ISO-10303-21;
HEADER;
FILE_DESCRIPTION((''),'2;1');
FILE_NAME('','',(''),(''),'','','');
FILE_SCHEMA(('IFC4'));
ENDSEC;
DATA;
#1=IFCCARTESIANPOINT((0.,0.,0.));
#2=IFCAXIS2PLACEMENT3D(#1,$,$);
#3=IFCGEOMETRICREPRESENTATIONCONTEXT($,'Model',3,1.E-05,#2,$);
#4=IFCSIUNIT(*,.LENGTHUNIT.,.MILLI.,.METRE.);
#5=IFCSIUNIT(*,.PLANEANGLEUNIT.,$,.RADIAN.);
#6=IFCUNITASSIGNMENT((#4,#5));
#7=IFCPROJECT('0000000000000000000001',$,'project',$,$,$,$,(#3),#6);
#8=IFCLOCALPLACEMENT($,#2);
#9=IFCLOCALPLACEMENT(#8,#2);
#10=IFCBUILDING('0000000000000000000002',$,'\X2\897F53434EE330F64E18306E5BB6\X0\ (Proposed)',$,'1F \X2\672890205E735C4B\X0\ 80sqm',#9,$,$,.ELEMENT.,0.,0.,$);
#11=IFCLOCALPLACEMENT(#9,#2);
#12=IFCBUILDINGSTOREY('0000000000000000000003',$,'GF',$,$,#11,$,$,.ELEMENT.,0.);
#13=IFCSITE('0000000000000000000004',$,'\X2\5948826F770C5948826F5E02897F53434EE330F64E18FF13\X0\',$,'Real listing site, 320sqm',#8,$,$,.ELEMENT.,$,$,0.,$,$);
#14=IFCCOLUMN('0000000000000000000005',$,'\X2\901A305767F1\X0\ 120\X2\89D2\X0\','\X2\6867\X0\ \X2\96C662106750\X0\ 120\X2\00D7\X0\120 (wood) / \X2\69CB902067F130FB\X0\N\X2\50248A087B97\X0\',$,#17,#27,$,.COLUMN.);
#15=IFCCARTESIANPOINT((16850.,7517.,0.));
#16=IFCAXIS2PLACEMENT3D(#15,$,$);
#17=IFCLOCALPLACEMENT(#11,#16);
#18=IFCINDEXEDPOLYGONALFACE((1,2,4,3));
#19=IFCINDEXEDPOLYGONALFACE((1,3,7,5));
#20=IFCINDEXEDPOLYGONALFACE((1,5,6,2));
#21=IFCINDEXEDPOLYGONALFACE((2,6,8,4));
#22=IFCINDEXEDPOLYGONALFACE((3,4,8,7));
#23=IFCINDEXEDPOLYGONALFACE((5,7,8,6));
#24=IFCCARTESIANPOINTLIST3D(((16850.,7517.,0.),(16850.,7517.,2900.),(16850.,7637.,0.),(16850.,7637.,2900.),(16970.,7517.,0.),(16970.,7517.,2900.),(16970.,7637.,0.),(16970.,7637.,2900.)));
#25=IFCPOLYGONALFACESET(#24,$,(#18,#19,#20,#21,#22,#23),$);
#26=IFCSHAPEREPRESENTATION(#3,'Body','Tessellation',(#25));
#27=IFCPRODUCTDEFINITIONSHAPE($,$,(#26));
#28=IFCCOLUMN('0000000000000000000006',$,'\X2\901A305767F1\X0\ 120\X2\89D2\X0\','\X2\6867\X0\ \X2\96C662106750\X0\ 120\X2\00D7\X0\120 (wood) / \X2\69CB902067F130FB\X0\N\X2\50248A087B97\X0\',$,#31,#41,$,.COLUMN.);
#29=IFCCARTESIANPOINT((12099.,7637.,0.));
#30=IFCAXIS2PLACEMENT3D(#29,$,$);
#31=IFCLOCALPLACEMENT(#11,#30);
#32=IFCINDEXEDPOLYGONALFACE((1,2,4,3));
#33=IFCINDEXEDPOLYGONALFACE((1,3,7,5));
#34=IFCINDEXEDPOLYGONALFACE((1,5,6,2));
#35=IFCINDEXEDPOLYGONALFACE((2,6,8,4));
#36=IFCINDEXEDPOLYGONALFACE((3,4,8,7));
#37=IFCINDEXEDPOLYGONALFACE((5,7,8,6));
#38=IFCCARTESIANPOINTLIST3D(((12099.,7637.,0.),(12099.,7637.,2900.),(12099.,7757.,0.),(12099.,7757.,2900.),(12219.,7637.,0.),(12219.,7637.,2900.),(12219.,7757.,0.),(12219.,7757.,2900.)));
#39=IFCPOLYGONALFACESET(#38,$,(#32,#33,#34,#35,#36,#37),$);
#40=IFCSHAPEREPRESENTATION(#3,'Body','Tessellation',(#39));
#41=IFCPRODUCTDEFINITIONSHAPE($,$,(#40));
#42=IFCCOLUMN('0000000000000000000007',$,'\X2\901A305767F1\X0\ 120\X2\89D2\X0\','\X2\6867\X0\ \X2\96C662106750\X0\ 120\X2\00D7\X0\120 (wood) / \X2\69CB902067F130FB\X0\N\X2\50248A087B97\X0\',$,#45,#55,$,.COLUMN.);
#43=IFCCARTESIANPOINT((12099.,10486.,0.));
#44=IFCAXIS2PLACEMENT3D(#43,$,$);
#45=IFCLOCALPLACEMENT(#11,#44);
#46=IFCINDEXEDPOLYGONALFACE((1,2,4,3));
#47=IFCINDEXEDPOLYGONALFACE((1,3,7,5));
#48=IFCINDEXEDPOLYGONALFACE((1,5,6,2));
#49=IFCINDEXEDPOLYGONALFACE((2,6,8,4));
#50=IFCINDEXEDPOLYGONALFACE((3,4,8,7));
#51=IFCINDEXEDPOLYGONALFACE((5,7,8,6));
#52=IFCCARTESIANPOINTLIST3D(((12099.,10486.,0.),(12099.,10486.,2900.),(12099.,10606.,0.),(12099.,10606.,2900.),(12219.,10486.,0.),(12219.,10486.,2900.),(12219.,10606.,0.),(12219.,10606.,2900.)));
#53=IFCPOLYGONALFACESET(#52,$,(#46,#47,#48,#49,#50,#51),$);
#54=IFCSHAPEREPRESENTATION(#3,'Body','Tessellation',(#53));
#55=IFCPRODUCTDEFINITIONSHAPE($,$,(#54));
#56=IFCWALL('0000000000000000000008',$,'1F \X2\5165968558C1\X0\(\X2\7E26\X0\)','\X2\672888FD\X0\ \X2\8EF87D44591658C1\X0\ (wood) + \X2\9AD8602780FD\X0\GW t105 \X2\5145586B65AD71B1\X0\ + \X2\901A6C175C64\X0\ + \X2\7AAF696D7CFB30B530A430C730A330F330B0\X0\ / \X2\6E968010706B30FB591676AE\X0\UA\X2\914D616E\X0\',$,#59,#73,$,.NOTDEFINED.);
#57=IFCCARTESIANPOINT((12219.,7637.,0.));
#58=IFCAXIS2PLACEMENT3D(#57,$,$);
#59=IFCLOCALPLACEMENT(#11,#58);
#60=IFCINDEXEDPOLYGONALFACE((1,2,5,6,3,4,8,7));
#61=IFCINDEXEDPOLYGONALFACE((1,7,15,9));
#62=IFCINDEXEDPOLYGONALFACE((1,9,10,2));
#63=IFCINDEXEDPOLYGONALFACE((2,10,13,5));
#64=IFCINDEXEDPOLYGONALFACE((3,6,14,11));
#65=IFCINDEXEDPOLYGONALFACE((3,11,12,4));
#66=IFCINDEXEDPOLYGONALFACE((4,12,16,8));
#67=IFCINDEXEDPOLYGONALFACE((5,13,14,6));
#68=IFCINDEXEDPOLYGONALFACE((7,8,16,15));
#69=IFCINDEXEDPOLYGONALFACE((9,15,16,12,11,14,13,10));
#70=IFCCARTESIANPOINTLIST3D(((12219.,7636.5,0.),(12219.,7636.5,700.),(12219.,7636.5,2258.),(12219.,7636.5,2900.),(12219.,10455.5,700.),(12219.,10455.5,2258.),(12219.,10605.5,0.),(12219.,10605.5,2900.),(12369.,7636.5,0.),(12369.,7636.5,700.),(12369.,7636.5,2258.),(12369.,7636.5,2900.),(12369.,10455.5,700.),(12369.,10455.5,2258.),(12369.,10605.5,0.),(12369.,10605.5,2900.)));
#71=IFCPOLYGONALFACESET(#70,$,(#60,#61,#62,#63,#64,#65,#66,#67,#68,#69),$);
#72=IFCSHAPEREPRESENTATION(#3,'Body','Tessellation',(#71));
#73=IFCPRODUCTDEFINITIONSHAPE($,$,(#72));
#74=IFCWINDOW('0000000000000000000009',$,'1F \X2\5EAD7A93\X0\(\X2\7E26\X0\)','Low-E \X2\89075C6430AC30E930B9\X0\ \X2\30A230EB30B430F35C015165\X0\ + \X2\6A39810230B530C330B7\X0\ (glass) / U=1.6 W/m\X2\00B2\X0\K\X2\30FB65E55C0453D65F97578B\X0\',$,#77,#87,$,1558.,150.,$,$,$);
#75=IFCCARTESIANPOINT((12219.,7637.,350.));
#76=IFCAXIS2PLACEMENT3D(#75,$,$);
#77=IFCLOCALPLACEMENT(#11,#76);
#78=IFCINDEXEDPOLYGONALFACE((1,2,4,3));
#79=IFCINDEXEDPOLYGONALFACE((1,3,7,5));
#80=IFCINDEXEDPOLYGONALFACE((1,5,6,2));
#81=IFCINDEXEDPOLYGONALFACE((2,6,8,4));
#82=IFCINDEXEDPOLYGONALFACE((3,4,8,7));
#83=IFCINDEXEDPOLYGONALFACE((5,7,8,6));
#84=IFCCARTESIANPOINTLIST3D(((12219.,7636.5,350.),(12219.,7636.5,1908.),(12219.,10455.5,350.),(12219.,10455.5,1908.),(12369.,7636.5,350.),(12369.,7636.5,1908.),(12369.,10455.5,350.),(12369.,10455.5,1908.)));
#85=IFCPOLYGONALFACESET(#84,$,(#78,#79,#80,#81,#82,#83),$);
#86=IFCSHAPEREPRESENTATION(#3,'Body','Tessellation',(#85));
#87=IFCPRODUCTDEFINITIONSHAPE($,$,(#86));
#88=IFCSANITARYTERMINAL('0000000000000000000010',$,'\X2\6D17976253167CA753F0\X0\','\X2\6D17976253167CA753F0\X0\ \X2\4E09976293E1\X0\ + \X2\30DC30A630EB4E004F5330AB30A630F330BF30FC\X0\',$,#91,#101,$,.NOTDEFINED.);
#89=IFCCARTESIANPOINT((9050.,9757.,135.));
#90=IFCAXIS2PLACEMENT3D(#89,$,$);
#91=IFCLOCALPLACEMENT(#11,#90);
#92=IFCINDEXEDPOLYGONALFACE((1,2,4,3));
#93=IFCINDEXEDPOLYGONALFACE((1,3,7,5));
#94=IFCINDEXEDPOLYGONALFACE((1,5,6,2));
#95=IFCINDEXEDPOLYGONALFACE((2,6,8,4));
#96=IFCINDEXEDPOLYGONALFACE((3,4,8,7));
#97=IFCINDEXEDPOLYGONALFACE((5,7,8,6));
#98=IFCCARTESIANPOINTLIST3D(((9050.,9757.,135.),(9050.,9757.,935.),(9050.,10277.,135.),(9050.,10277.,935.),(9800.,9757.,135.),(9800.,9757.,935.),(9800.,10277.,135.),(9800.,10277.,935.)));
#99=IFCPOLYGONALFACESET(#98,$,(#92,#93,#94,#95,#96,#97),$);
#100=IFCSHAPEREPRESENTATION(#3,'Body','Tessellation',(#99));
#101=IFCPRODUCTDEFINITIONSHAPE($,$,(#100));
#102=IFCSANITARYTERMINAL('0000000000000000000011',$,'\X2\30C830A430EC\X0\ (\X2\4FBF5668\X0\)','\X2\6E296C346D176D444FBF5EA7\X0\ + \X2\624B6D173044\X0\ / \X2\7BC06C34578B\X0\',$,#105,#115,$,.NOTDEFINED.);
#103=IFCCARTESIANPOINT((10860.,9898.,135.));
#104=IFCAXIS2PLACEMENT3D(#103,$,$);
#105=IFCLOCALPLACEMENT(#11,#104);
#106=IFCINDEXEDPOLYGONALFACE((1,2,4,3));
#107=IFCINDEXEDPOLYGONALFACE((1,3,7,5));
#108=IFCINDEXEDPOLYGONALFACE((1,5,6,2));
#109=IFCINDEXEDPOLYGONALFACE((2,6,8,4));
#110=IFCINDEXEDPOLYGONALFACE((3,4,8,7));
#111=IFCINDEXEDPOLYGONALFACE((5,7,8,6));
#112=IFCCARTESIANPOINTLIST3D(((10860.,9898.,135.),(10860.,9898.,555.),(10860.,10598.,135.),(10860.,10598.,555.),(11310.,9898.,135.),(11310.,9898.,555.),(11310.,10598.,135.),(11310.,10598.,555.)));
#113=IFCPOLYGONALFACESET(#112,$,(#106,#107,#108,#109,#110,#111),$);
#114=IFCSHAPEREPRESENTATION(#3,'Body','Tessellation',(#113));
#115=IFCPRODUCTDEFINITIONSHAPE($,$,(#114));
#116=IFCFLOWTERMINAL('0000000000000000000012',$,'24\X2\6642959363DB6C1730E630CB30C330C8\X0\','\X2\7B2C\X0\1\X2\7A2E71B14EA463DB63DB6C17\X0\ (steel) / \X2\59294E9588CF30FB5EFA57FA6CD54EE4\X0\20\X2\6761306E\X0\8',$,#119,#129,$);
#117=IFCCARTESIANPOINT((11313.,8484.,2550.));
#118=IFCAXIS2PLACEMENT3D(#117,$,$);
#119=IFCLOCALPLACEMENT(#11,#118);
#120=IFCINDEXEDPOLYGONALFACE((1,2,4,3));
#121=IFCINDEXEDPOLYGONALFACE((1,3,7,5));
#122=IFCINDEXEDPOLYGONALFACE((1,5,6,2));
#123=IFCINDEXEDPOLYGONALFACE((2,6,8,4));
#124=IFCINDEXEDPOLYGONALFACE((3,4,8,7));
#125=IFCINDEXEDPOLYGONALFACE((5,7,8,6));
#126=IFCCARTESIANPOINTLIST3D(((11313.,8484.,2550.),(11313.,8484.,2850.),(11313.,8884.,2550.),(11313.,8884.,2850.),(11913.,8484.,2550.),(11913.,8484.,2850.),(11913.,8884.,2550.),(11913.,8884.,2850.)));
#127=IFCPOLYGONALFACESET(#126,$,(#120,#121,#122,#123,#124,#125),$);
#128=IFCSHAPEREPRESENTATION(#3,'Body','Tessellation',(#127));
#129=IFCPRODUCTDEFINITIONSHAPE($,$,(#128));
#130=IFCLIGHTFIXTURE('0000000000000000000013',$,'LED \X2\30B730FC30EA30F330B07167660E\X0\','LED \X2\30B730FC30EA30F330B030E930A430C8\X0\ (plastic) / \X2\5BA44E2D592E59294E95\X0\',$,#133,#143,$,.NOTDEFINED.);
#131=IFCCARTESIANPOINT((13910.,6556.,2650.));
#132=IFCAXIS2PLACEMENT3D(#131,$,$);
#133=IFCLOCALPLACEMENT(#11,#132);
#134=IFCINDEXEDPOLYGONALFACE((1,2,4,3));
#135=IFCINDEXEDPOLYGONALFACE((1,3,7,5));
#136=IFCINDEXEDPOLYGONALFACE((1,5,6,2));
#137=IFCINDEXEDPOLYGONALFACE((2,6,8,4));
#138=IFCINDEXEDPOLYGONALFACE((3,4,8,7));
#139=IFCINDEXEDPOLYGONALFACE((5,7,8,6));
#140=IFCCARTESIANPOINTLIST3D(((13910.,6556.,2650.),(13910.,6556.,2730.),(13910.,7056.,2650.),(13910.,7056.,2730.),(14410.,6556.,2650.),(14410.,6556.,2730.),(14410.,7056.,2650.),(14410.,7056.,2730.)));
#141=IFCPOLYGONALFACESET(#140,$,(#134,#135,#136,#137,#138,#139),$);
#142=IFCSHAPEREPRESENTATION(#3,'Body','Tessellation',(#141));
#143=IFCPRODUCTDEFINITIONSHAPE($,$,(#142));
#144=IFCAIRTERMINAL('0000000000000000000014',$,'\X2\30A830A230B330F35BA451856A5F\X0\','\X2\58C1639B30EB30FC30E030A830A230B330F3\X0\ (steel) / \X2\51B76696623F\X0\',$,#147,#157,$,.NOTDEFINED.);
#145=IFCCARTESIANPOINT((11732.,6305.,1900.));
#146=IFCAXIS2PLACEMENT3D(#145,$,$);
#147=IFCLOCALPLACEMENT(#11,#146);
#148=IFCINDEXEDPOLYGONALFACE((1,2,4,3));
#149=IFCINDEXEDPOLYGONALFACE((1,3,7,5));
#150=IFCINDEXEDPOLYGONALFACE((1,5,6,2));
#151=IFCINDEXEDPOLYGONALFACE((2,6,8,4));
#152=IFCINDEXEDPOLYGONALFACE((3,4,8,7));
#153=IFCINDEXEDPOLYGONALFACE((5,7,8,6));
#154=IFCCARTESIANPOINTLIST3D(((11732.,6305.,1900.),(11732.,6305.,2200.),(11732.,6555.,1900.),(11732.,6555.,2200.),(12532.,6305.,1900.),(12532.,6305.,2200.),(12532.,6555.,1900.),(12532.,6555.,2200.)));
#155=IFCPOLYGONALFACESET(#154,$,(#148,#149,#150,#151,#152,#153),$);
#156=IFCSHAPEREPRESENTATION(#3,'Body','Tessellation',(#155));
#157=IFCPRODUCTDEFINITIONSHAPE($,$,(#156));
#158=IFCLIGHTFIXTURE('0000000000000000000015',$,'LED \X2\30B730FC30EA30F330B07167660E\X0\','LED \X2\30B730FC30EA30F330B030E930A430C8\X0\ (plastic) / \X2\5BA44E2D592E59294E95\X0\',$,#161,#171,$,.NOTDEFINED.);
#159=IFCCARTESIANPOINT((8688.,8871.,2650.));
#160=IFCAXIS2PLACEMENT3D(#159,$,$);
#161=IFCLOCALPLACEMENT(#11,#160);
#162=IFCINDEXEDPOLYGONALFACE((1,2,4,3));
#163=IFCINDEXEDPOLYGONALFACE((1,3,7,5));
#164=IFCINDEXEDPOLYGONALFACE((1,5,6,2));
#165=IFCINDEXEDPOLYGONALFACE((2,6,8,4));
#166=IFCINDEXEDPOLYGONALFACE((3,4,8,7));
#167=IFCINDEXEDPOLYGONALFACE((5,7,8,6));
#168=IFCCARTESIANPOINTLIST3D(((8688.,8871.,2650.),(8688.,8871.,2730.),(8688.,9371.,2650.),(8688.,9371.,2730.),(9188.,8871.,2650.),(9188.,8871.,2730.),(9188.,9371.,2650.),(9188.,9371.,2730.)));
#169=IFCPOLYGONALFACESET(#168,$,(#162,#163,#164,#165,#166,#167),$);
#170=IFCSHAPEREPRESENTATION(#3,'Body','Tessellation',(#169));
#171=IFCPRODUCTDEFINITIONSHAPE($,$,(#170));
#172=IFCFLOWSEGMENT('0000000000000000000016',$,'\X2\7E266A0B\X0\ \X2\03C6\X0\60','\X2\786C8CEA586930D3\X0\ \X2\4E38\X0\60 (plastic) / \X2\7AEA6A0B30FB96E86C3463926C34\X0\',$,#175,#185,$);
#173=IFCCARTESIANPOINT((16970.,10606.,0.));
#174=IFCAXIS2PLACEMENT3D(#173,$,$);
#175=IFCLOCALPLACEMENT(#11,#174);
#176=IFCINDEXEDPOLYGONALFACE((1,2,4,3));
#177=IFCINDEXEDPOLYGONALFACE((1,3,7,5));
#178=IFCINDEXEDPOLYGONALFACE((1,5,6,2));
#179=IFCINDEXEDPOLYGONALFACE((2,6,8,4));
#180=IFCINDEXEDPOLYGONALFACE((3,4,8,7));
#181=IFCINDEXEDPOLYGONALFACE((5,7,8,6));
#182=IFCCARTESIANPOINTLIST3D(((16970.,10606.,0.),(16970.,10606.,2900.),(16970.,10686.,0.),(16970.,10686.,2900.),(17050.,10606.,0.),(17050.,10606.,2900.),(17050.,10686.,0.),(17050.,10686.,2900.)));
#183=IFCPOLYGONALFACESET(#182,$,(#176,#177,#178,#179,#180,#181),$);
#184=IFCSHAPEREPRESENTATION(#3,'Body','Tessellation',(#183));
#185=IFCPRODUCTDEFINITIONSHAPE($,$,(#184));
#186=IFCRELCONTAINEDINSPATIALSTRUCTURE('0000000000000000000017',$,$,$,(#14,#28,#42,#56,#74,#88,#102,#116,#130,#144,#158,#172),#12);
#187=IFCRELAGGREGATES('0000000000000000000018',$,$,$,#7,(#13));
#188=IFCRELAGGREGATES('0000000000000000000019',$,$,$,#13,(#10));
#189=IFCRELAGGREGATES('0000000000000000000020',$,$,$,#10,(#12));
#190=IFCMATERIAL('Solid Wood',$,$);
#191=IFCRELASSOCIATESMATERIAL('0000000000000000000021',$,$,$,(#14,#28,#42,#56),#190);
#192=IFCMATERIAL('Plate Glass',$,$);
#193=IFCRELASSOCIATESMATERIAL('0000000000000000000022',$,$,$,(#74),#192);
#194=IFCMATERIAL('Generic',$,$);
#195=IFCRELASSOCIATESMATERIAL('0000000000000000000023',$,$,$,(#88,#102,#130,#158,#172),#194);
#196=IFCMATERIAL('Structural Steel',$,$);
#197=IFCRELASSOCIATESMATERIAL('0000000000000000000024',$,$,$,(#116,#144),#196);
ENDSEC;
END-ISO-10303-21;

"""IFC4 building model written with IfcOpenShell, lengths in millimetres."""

from ifc_helpers import new_model, si_unit, frame, frame_2d, origin, place, context, project, spatial, rectangle, extrude, material, element, fill, save


model = new_model("IFC4")

# Units and contexts
model_context = context("Model", 3, precision=1e-05, world=origin())
ifc_project = project(units=[si_unit("LENGTHUNIT", "METRE", prefix="MILLI"), si_unit("PLANEANGLEUNIT", "RADIAN")], contexts=[model_context])

# Site, building, storey
site_placement = place(None, origin())
site = spatial("IfcSite", under=ifc_project, at=site_placement, Name="奈良県奈良市西千代ヶ丘３", ObjectType="Real listing site, 320sqm", CompositionType="ELEMENT", RefElevation=0.0)
building_placement = place(site_placement, origin())
building = spatial("IfcBuilding", under=site, at=building_placement, Name="西千代ヶ丘の家 (Proposed)", ObjectType="1F 木造平屋 80sqm", CompositionType="ELEMENT", ElevationOfRefHeight=0.0, ElevationOfTerrain=0.0)
storey_placement = place(building_placement, origin())
storey = spatial("IfcBuildingStorey", under=building, at=storey_placement, Name="GF", CompositionType="ELEMENT", Elevation=0.0)

# Columns
ifc_material_1 = material(Name="Solid Wood")
column_1_placement = place(storey_placement, frame((16850.0, 7517.0, 0.0)))
element("IfcColumn", 1, at=column_1_placement, inside=storey, material=ifc_material_1, Name="通し柱 120角", Description="桧 集成材 120×120 (wood) / 構造柱・N値計算", PredefinedType="COLUMN", context=model_context, shape_type="SweptSolid", body=[
    extrude(rectangle(XDim=120.0, YDim=120.0, at=frame_2d((60.0, 60.0))), frame((16850.0, 7517.0, 0.0)), (0.0, 0.0, 1.0), 2900.0),
])
column_2_placement = place(storey_placement, frame((12099.0, 7637.0, 0.0)))
element("IfcColumn", 2, at=column_2_placement, inside=storey, material=ifc_material_1, Name="通し柱 120角", Description="桧 集成材 120×120 (wood) / 構造柱・N値計算", PredefinedType="COLUMN", context=model_context, shape_type="SweptSolid", body=[
    extrude(rectangle(XDim=120.0, YDim=120.0, at=frame_2d((60.0, 60.0))), frame((12099.0, 7637.0, 0.0)), (0.0, 0.0, 1.0), 2900.0),
])
column_3_placement = place(storey_placement, frame((12099.0, 10486.0, 0.0)))
element("IfcColumn", 3, at=column_3_placement, inside=storey, material=ifc_material_1, Name="通し柱 120角", Description="桧 集成材 120×120 (wood) / 構造柱・N値計算", PredefinedType="COLUMN", context=model_context, shape_type="SweptSolid", body=[
    extrude(rectangle(XDim=120.0, YDim=120.0, at=frame_2d((60.0, 60.0))), frame((12099.0, 10486.0, 0.0)), (0.0, 0.0, 1.0), 2900.0),
])

# Wall, opening, window
wall_1_placement = place(storey_placement, frame((12219.0, 7637.0, 0.0)))
wall_1 = element("IfcWall", 4, at=wall_1_placement, inside=storey, material=ifc_material_1, Name="1F 入隅壁(縦)", Description="木製 軸組外壁 (wood) + 高性能GW t105 充填断熱 + 通気層 + 窯業系サイディング / 準耐火・外皮UA配慮", PredefinedType="NOTDEFINED", context=model_context, shape_type="SweptSolid", body=[
    extrude(rectangle(XDim=150.0, YDim=2969.0, at=frame_2d((75.0, 1484.0))), frame((12219.0, 7637.0, 0.0)), (0.0, 0.0, 1.0), 2900.0),
])
opening_placement = place(storey_placement, frame((12219.0, 7637.0, 350.0)))
opening = element("IfcOpeningElement", 5, at=opening_placement, cuts=wall_1, PredefinedType="NOTDEFINED", context=model_context, shape_type="SweptSolid", body=[
    extrude(rectangle(XDim=150.0, YDim=2819.0, at=frame_2d((75.0, 1409.0))), frame((12219.0, 7637.0, 350.0)), (0.0, 0.0, 1.0), 1558.0),
])
ifc_material_2 = material(Name="Plate Glass")
window_placement = place(storey_placement, frame((12219.0, 7637.0, 350.0)))
window = element("IfcWindow", 6, at=window_placement, inside=storey, material=ifc_material_2, Name="1F 庭窓(縦)", Description="Low-E 複層ガラス アルゴン封入 + 樹脂サッシ (glass) / U=1.6 W/m²K・日射取得型", OverallHeight=1558.0, OverallWidth=150.0, context=model_context, shape_type="SweptSolid", body=[
    extrude(rectangle(XDim=150.0, YDim=2819.0, at=frame_2d((75.0, 1409.0))), frame((12219.0, 7637.0, 350.0)), (0.0, 0.0, 1.0), 1558.0),
])
fill(opening, window)

# Sanitary terminals
ifc_material_3 = material(Name="Generic")
sanitary_terminal_1_placement = place(storey_placement, frame((9050.0, 9757.0, 135.0)))
element("IfcSanitaryTerminal", 7, at=sanitary_terminal_1_placement, inside=storey, material=ifc_material_3, Name="洗面化粧台", Description="洗面化粧台 三面鏡 + ボウル一体カウンター", PredefinedType="NOTDEFINED", context=model_context, shape_type="SweptSolid", body=[
    extrude(rectangle(XDim=750.0, YDim=520.0, at=frame_2d((375.0, 260.0))), frame((9050.0, 9757.0, 135.0)), (0.0, 0.0, 1.0), 800.0),
])
sanitary_terminal_2_placement = place(storey_placement, frame((10860.0, 9898.0, 135.0)))
element("IfcSanitaryTerminal", 8, at=sanitary_terminal_2_placement, inside=storey, material=ifc_material_3, Name="トイレ (便器)", Description="温水洗浄便座 + 手洗い / 節水型", PredefinedType="NOTDEFINED", context=model_context, shape_type="SweptSolid", body=[
    extrude(rectangle(XDim=450.0, YDim=700.0, at=frame_2d((225.0, 350.0))), frame((10860.0, 9898.0, 135.0)), (0.0, 0.0, 1.0), 420.0),
])

# Flow terminal
ifc_material_4 = material(Name="Structural Steel")
flow_terminal_placement = place(storey_placement, frame((11313.0, 8484.0, 2550.0)))
element("IfcFlowTerminal", 9, at=flow_terminal_placement, inside=storey, material=ifc_material_4, Name="24時間換気ユニット", Description="第1種熱交換換気 (steel) / 天井裏・建基法令20条の8", context=model_context, shape_type="SweptSolid", body=[
    extrude(rectangle(XDim=600.0, YDim=400.0, at=frame_2d((300.0, 200.0))), frame((11313.0, 8484.0, 2550.0)), (0.0, 0.0, 1.0), 300.0),
])

# Light fixture
light_fixture_1_placement = place(storey_placement, frame((13910.0, 6556.0, 2650.0)))
element("IfcLightFixture", 10, at=light_fixture_1_placement, inside=storey, material=ifc_material_3, Name="LED シーリング照明", Description="LED シーリングライト (plastic) / 室中央天井", PredefinedType="NOTDEFINED", context=model_context, shape_type="SweptSolid", body=[
    extrude(rectangle(XDim=500.0, YDim=500.0, at=frame_2d((250.0, 250.0))), frame((13910.0, 6556.0, 2650.0)), (0.0, 0.0, 1.0), 80.0),
])

# Air terminal
air_terminal_placement = place(storey_placement, frame((11732.0, 6305.0, 1900.0)))
element("IfcAirTerminal", 11, at=air_terminal_placement, inside=storey, material=ifc_material_4, Name="エアコン室内機", Description="壁掛ルームエアコン (steel) / 冷暖房", PredefinedType="NOTDEFINED", context=model_context, shape_type="SweptSolid", body=[
    extrude(rectangle(XDim=800.0, YDim=250.0, at=frame_2d((400.0, 125.0))), frame((11732.0, 6305.0, 1900.0)), (0.0, 0.0, 1.0), 300.0),
])

# Light fixture
light_fixture_2_placement = place(storey_placement, frame((8688.0, 8871.0, 2650.0)))
element("IfcLightFixture", 12, at=light_fixture_2_placement, inside=storey, material=ifc_material_3, Name="LED シーリング照明", Description="LED シーリングライト (plastic) / 室中央天井", PredefinedType="NOTDEFINED", context=model_context, shape_type="SweptSolid", body=[
    extrude(rectangle(XDim=500.0, YDim=500.0, at=frame_2d((250.0, 250.0))), frame((8688.0, 8871.0, 2650.0)), (0.0, 0.0, 1.0), 80.0),
])

# Flow segment
flow_segment_placement = place(storey_placement, frame((16970.0, 10606.0, 0.0)))
element("IfcFlowSegment", 13, at=flow_segment_placement, inside=storey, material=ifc_material_3, Name="縦樋 φ60", Description="硬質塩ビ 丸60 (plastic) / 竪樋・雨水排水", context=model_context, shape_type="SweptSolid", body=[
    extrude(rectangle(XDim=80.0, YDim=80.0, at=frame_2d((40.0, 40.0))), frame((16970.0, 10606.0, 0.0)), (0.0, 0.0, 1.0), 2900.0),
])

save(model, "model.ifc")
